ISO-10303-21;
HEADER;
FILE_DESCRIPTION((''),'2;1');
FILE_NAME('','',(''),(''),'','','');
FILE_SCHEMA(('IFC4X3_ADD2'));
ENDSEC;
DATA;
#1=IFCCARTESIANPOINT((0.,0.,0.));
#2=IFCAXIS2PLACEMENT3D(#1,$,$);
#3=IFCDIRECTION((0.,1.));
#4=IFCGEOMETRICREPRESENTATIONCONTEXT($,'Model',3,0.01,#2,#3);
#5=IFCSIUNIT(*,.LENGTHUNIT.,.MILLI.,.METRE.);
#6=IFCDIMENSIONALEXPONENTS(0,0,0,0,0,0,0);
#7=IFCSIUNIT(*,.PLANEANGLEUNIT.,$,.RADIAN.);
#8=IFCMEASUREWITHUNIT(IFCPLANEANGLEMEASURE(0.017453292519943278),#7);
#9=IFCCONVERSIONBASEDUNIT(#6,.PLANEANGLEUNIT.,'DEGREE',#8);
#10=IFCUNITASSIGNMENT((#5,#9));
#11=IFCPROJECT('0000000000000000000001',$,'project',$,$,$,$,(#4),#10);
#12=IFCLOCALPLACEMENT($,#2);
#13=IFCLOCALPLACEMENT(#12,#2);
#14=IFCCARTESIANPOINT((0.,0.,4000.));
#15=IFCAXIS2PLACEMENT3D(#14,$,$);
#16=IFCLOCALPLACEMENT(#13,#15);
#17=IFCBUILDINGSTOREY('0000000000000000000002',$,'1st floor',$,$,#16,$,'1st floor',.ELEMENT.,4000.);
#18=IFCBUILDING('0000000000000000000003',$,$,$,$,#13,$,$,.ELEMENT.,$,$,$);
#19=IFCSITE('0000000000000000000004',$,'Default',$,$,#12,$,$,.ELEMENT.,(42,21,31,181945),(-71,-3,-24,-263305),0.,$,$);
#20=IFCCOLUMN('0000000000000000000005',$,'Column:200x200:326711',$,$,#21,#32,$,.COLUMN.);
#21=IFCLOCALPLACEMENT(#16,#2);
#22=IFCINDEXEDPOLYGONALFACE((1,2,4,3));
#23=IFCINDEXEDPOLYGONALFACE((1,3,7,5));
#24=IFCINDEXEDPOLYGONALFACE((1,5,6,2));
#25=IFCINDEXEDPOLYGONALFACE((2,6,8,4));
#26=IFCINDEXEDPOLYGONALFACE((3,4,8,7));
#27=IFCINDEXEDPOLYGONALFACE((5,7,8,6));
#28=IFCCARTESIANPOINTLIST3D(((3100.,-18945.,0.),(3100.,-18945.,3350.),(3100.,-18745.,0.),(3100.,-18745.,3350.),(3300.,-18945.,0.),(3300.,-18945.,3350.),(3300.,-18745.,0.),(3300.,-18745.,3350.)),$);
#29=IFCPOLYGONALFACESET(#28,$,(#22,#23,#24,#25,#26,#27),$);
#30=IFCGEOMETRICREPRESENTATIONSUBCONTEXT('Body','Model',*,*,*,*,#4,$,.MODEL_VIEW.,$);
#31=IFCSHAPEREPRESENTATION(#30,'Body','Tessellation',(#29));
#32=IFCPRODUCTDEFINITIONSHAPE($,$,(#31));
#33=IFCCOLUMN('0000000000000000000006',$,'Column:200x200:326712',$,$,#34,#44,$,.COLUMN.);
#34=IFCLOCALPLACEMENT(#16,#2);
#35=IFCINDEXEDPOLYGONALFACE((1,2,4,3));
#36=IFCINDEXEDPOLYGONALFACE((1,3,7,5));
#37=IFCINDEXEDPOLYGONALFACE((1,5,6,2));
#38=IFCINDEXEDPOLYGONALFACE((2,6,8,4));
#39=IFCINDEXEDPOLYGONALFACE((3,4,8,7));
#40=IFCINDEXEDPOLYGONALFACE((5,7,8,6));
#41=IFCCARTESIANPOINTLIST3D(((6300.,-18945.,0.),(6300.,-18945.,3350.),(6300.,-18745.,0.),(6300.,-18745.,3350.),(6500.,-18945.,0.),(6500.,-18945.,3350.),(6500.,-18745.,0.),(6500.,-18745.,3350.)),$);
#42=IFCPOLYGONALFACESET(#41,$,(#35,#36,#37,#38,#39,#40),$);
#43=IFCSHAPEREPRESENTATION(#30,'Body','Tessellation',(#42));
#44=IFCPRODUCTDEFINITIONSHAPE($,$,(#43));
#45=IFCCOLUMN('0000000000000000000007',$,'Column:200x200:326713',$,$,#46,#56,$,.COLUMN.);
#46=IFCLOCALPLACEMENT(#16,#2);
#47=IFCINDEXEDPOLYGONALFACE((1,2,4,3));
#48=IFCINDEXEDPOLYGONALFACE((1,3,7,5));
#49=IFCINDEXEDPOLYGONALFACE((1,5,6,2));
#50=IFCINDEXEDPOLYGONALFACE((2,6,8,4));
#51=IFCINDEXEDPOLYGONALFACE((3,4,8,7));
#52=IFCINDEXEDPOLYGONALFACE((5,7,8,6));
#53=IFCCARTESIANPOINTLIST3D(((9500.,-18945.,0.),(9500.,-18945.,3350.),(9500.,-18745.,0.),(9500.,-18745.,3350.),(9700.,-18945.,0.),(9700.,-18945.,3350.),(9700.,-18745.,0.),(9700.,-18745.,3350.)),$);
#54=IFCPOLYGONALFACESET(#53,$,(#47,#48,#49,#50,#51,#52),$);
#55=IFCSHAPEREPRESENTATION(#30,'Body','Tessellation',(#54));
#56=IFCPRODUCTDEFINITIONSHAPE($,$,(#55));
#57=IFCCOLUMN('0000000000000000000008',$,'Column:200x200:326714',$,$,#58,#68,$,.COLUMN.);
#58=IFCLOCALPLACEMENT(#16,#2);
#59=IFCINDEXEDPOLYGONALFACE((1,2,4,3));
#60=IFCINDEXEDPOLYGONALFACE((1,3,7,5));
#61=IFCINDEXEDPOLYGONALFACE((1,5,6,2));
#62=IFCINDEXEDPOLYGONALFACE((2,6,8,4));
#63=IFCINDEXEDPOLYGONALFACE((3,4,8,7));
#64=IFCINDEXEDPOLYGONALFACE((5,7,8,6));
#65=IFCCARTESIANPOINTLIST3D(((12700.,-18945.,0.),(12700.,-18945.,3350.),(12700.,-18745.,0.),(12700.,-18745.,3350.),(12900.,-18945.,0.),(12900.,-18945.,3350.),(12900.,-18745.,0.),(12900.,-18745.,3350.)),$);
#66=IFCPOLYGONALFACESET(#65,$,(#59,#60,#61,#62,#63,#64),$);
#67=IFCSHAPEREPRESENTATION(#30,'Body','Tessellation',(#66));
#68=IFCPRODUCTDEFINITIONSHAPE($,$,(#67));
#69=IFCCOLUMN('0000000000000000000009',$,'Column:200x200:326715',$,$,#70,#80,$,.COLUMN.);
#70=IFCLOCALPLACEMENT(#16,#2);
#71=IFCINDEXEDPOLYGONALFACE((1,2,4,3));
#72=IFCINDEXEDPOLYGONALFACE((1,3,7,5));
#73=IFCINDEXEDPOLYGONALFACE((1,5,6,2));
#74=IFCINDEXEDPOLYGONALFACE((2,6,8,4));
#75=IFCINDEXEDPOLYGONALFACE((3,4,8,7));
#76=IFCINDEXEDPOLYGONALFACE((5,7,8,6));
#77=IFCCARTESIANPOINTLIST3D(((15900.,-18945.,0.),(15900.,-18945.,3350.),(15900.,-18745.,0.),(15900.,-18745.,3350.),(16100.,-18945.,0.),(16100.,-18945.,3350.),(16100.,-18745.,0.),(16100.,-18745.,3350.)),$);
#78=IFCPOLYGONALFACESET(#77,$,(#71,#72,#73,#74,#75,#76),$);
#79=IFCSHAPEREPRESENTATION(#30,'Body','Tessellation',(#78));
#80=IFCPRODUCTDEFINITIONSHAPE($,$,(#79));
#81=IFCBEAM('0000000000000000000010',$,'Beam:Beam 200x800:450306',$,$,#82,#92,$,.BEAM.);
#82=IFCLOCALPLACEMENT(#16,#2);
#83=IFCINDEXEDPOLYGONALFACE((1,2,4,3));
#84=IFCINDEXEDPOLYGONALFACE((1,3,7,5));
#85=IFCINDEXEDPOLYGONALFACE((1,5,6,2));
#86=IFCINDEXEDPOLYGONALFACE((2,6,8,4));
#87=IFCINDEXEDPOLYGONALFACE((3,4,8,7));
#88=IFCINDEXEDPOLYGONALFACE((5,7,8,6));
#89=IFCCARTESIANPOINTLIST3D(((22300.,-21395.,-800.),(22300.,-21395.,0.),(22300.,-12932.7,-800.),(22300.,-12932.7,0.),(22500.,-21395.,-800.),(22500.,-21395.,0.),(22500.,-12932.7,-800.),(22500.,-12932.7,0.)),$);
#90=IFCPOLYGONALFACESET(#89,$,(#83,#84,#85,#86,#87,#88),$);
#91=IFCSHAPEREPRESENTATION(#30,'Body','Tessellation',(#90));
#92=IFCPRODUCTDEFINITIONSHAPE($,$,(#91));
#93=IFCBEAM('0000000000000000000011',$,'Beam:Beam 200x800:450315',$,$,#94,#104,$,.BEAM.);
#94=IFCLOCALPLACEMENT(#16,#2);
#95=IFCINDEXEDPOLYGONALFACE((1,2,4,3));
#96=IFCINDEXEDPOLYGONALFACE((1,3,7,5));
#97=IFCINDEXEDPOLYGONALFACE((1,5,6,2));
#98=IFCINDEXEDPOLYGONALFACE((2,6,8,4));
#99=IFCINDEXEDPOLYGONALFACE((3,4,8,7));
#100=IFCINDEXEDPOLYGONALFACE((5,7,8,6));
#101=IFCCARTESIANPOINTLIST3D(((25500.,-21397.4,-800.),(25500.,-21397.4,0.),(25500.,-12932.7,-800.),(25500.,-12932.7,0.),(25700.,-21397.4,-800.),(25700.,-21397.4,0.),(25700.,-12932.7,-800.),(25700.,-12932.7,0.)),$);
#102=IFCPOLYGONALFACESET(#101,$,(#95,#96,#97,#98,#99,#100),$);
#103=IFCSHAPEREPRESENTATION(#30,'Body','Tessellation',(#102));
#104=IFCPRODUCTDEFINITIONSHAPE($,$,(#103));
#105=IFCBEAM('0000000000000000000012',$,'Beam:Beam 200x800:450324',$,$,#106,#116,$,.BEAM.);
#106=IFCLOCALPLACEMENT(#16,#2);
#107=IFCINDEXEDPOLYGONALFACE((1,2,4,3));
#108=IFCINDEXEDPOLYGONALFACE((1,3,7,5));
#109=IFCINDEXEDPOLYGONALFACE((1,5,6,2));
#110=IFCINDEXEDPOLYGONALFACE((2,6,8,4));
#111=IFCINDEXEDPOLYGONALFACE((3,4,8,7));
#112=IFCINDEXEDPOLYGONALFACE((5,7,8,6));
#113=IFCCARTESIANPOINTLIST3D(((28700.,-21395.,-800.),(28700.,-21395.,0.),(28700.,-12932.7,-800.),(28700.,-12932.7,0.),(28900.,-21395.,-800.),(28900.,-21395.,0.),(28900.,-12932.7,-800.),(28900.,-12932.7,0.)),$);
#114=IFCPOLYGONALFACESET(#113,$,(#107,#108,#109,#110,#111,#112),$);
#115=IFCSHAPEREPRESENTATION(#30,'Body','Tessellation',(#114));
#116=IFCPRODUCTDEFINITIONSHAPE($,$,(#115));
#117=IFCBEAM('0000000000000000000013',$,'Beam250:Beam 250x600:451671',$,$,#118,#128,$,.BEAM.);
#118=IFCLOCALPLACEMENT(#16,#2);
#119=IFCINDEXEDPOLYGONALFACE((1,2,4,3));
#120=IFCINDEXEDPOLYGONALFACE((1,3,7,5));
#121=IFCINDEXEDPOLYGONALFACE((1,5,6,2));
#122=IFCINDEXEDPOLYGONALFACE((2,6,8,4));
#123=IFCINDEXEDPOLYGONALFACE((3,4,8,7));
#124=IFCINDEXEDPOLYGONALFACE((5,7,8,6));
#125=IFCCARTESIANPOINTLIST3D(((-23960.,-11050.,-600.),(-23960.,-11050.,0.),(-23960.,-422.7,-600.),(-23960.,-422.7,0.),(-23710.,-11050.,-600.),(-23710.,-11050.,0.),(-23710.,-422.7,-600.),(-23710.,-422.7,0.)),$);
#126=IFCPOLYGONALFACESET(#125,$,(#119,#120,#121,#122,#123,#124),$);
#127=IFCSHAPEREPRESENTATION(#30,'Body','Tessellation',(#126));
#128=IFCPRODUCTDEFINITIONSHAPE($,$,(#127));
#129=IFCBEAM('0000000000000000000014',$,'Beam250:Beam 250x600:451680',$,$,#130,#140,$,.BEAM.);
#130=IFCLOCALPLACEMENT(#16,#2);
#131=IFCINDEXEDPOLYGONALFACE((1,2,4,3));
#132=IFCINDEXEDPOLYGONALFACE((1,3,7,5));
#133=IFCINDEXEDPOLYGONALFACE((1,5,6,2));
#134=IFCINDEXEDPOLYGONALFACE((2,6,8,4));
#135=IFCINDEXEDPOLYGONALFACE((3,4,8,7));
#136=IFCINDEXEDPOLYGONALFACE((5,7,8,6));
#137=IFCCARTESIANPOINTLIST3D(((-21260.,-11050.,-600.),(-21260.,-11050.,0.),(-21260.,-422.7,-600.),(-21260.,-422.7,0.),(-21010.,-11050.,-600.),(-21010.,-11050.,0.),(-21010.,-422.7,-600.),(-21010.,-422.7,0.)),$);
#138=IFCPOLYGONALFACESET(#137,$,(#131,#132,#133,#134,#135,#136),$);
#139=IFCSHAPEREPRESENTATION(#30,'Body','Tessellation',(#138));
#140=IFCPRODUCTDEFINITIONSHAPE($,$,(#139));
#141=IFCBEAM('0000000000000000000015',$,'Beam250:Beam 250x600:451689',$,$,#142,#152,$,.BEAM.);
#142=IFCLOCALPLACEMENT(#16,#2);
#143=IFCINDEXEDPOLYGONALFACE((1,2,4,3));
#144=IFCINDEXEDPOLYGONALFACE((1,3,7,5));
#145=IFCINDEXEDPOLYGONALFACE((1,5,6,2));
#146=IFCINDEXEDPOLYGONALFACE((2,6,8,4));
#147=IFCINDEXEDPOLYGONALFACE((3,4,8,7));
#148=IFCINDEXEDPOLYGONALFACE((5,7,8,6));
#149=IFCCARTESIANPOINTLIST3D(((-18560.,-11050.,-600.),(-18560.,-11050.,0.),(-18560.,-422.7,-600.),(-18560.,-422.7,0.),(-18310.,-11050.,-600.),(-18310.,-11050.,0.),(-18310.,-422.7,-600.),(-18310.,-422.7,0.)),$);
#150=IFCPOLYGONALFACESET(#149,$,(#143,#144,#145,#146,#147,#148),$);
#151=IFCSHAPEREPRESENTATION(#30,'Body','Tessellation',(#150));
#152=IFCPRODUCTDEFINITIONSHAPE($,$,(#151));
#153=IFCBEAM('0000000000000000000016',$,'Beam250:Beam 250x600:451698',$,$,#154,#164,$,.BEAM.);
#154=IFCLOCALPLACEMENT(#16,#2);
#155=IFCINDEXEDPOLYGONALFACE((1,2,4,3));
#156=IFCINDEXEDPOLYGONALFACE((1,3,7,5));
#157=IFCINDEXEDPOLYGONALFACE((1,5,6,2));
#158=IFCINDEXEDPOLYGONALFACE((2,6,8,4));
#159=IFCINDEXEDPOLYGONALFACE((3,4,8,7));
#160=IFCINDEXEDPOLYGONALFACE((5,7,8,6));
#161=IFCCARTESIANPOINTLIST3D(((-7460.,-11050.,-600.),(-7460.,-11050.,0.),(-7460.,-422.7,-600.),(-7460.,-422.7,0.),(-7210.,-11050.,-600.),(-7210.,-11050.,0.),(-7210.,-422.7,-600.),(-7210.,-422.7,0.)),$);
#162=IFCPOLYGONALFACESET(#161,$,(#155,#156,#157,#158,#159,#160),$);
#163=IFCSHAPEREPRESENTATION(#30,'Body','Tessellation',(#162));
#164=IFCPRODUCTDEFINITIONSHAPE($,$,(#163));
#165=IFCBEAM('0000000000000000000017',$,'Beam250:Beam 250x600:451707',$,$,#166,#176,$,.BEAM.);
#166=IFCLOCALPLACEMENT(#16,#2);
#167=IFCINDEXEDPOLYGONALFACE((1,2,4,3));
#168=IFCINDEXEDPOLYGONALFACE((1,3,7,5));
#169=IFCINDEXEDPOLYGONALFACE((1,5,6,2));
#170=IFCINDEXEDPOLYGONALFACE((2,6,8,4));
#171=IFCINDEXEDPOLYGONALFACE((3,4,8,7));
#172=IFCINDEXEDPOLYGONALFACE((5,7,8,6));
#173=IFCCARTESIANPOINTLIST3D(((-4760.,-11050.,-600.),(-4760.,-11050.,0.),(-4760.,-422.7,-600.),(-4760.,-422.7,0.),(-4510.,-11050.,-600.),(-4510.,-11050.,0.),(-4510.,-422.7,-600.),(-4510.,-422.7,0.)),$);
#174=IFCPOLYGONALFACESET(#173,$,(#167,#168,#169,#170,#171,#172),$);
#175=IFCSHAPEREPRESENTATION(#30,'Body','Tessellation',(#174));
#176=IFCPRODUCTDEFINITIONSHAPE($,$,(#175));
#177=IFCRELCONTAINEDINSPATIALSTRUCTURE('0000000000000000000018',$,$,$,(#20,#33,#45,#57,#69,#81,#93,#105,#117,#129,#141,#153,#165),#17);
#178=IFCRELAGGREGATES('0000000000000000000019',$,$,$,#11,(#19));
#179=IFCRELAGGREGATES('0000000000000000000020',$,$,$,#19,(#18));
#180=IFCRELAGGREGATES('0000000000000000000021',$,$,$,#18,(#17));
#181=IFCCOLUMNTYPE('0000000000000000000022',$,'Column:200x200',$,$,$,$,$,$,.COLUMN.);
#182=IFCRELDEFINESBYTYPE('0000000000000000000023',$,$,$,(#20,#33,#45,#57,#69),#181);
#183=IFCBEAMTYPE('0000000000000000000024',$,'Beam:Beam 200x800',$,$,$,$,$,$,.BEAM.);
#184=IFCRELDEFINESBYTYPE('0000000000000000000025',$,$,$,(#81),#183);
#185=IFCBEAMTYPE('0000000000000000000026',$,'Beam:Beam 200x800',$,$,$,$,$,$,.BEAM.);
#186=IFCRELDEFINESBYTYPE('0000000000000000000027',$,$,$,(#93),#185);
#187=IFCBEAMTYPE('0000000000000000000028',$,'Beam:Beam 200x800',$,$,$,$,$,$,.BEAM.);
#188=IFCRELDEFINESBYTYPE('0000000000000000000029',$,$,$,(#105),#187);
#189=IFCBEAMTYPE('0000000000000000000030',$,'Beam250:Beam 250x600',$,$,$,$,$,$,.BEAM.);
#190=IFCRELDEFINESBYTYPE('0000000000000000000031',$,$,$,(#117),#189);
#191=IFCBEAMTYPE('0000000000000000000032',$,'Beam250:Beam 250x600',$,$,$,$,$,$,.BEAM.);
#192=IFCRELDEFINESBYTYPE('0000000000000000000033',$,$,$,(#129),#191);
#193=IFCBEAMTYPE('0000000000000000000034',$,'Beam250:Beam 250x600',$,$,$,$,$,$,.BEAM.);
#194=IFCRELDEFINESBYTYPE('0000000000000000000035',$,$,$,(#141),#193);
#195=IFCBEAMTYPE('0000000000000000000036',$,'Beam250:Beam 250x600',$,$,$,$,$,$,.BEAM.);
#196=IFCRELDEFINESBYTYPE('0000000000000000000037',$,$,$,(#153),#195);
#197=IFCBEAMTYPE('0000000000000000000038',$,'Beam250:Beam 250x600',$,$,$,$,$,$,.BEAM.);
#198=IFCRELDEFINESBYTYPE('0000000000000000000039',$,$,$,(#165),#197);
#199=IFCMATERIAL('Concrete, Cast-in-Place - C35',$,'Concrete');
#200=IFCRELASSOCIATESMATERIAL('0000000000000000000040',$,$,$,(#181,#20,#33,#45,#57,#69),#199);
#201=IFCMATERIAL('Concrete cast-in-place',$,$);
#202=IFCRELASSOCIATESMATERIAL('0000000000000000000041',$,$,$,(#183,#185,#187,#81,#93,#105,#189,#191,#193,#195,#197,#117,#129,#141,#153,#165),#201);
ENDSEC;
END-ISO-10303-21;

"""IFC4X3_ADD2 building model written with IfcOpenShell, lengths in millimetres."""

from ifc_helpers import new_model, entity, si_unit, converted_unit, direction, frame, frame_2d, origin, place, context, subcontext, project, spatial, rectangle, extrude, source, transform, mapped, material, material_profile, profile_set, profile_usage, type_object, type_shapes, element, save


model = new_model("IFC4X3_ADD2")

# Units and contexts
model_context = context("Model", 3, precision=0.01, world=origin(), true_north=direction((0.0, 1.0)))
body_context = subcontext(model_context, "Body", "Model", "MODEL_VIEW")
ifc_project = project(units=[si_unit("LENGTHUNIT", "METRE", prefix="MILLI"), converted_unit("PLANEANGLEUNIT", "DEGREE", entity("IfcPlaneAngleMeasure", 0.017453292519943278), si_unit("PLANEANGLEUNIT", "RADIAN"), dimensions=[0, 0, 0, 0, 0, 0, 0])], contexts=[model_context])

# Site, building, storey
site_placement = place(None, origin())
site = spatial("IfcSite", under=ifc_project, at=site_placement, Name="Default", CompositionType="ELEMENT", RefLatitude=(42, 21, 31, 181945), RefLongitude=(-71, -3, -24, -263305), RefElevation=0.0)
building_placement = place(site_placement, origin())
building = spatial("IfcBuilding", under=site, at=building_placement, CompositionType="ELEMENT")
storey_placement = place(building_placement, frame((0.0, 0.0, 4000.0)))
storey = spatial("IfcBuildingStorey", under=building, at=storey_placement, Name="1st floor", LongName="1st floor", CompositionType="ELEMENT", Elevation=4000.0)

# Columns
ifc_material_1 = material(Name="Concrete, Cast-in-Place - C35", Category="Concrete")
ifc_material_profile_1 = material_profile(ifc_material_1, rectangle(XDim=200.0, YDim=200.0, at=frame_2d((0.0, 0.0), x_axis=(1.0, 0.0))), Name="200x200")
ifc_profile_set_1 = profile_set([ifc_material_profile_1], Name="200x200")
ifc_profile_usage_1 = profile_usage(ifc_profile_set_1)
column_type_1 = type_object("IfcColumnType", Name="Column:200x200", PredefinedType="COLUMN", material=ifc_profile_set_1)
shared_shape_1 = source(origin(), body_context, "Body", "SweptSolid", [
    extrude(rectangle(XDim=200.0, YDim=200.0, at=frame_2d((0.0, 0.0), x_axis=(1.0, 0.0))), frame((0.0, 0.0, 4000.0), z_axis=(0.0, 0.0, 1.0), x_axis=(-1.0, 0.0, 0.0)), (0.0, 0.0, 1.0), 3350.0),
])
type_shapes(column_type_1, [shared_shape_1])
for number, where, name in (
    (1, (3200.0, -18845.0, -4000.0), "Column:200x200:326711"),
    (2, (6400.0, -18845.0, -4000.0), "Column:200x200:326712"),
    (3, (9600.0, -18845.0, -4000.0), "Column:200x200:326713"),
    (4, (12800.0, -18845.0, -4000.0), "Column:200x200:326714"),
    (5, (16000.0, -18845.0, -4000.0), "Column:200x200:326715"),
):
    element("IfcColumn", number, at=place(storey_placement, frame(where)), inside=storey, type_object=column_type_1, material=ifc_profile_usage_1, Name=name, PredefinedType="COLUMN", context=body_context, shape_type="MappedRepresentation", body=[
        mapped(shared_shape_1, transform((0.0, 0.0, 0.0), scale=1.0)),
    ])

# Beams
ifc_material_2 = material(Name="Concrete cast-in-place")
ifc_material_profile_2 = material_profile(ifc_material_2, rectangle(XDim=800.0, YDim=200.0, at=frame_2d((0.0, 0.0), x_axis=(0.0, 1.0))), Name="Beam 200x800")
ifc_profile_set_2 = profile_set([ifc_material_profile_2], Name="Beam 200x800")
ifc_profile_usage_2 = profile_usage(ifc_profile_set_2, cardinal=8)
beam_type_1 = type_object("IfcBeamType", Name="Beam:Beam 200x800", PredefinedType="BEAM", material=ifc_profile_set_2)
shared_shape_2 = source(origin(), body_context, "Body", "SweptSolid", [
    extrude(rectangle(XDim=800.0, YDim=200.0, at=frame_2d((0.0, 0.0), x_axis=(0.0, 1.0))), frame((22400.0, -12932.7, 3600.0), z_axis=(0.0, -1.0, 0.0), x_axis=(-1.0, 0.0, 0.0)), (0.0, 0.0, 1.0), 8462.3),
])
type_shapes(beam_type_1, [shared_shape_2])
beam_1_placement = place(storey_placement, frame((0.0, 0.0, -4000.0)))
element("IfcBeam", 6, at=beam_1_placement, inside=storey, type_object=beam_type_1, material=ifc_profile_usage_2, Name="Beam:Beam 200x800:450306", PredefinedType="BEAM", context=body_context, shape_type="MappedRepresentation", body=[
    mapped(shared_shape_2, transform((0.0, 0.0, 0.0), scale=1.0)),
])
beam_type_2 = type_object("IfcBeamType", Name="Beam:Beam 200x800", PredefinedType="BEAM", material=ifc_profile_set_2)
shared_shape_3 = source(origin(), body_context, "Body", "SweptSolid", [
    extrude(rectangle(XDim=800.0, YDim=200.0, at=frame_2d((0.0, 0.0), x_axis=(0.0, 1.0))), frame((25600.0, -12932.7, 3600.0), z_axis=(0.0, -1.0, 0.0), x_axis=(-1.0, 0.0, 0.0)), (0.0, 0.0, 1.0), 8464.7),
])
type_shapes(beam_type_2, [shared_shape_3])
beam_2_placement = place(storey_placement, frame((0.0, 0.0, -4000.0)))
element("IfcBeam", 7, at=beam_2_placement, inside=storey, type_object=beam_type_2, material=ifc_profile_usage_2, Name="Beam:Beam 200x800:450315", PredefinedType="BEAM", context=body_context, shape_type="MappedRepresentation", body=[
    mapped(shared_shape_3, transform((0.0, 0.0, 0.0), scale=1.0)),
])
beam_type_3 = type_object("IfcBeamType", Name="Beam:Beam 200x800", PredefinedType="BEAM", material=ifc_profile_set_2)
shared_shape_4 = source(origin(), body_context, "Body", "SweptSolid", [
    extrude(rectangle(XDim=800.0, YDim=200.0, at=frame_2d((0.0, 0.0), x_axis=(0.0, 1.0))), frame((28800.0, -12932.7, 3600.0), z_axis=(0.0, -1.0, 0.0), x_axis=(-1.0, 0.0, 0.0)), (0.0, 0.0, 1.0), 8462.3),
])
type_shapes(beam_type_3, [shared_shape_4])
beam_3_placement = place(storey_placement, frame((0.0, 0.0, -4000.0)))
element("IfcBeam", 8, at=beam_3_placement, inside=storey, type_object=beam_type_3, material=ifc_profile_usage_2, Name="Beam:Beam 200x800:450324", PredefinedType="BEAM", context=body_context, shape_type="MappedRepresentation", body=[
    mapped(shared_shape_4, transform((0.0, 0.0, 0.0), scale=1.0)),
])
ifc_material_profile_3 = material_profile(ifc_material_2, rectangle(XDim=600.0, YDim=250.0, at=frame_2d((0.0, 0.0), x_axis=(0.0, 1.0))), Name="Beam 250x600")
ifc_profile_set_3 = profile_set([ifc_material_profile_3], Name="Beam 250x600")
ifc_profile_usage_3 = profile_usage(ifc_profile_set_3, cardinal=8)
beam_type_4 = type_object("IfcBeamType", Name="Beam250:Beam 250x600", PredefinedType="BEAM", material=ifc_profile_set_3)
shared_shape_5 = source(origin(), body_context, "Body", "SweptSolid", [
    extrude(rectangle(XDim=600.0, YDim=250.0, at=frame_2d((0.0, 0.0), x_axis=(0.0, 1.0))), frame((-23835.0, -11050.0, 3700.0), z_axis=(0.0, 1.0, 0.0), x_axis=(-1.0, 0.0, 0.0)), (0.0, 0.0, 1.0), 10627.3),
])
type_shapes(beam_type_4, [shared_shape_5])
beam_4_placement = place(storey_placement, frame((0.0, 0.0, -4000.0)))
element("IfcBeam", 9, at=beam_4_placement, inside=storey, type_object=beam_type_4, material=ifc_profile_usage_3, Name="Beam250:Beam 250x600:451671", PredefinedType="BEAM", context=body_context, shape_type="MappedRepresentation", body=[
    mapped(shared_shape_5, transform((0.0, 0.0, 0.0), scale=1.0)),
])
beam_type_5 = type_object("IfcBeamType", Name="Beam250:Beam 250x600", PredefinedType="BEAM", material=ifc_profile_set_3)
shared_shape_6 = source(origin(), body_context, "Body", "SweptSolid", [
    extrude(rectangle(XDim=600.0, YDim=250.0, at=frame_2d((0.0, 0.0), x_axis=(0.0, 1.0))), frame((-21135.0, -11050.0, 3700.0), z_axis=(0.0, 1.0, 0.0), x_axis=(-1.0, 0.0, 0.0)), (0.0, 0.0, 1.0), 10627.3),
])
type_shapes(beam_type_5, [shared_shape_6])
beam_5_placement = place(storey_placement, frame((0.0, 0.0, -4000.0)))
element("IfcBeam", 10, at=beam_5_placement, inside=storey, type_object=beam_type_5, material=ifc_profile_usage_3, Name="Beam250:Beam 250x600:451680", PredefinedType="BEAM", context=body_context, shape_type="MappedRepresentation", body=[
    mapped(shared_shape_6, transform((0.0, 0.0, 0.0), scale=1.0)),
])
beam_type_6 = type_object("IfcBeamType", Name="Beam250:Beam 250x600", PredefinedType="BEAM", material=ifc_profile_set_3)
shared_shape_7 = source(origin(), body_context, "Body", "SweptSolid", [
    extrude(rectangle(XDim=600.0, YDim=250.0, at=frame_2d((0.0, 0.0), x_axis=(0.0, 1.0))), frame((-18435.0, -11050.0, 3700.0), z_axis=(0.0, 1.0, 0.0), x_axis=(-1.0, 0.0, 0.0)), (0.0, 0.0, 1.0), 10627.3),
])
type_shapes(beam_type_6, [shared_shape_7])
beam_6_placement = place(storey_placement, frame((0.0, 0.0, -4000.0)))
element("IfcBeam", 11, at=beam_6_placement, inside=storey, type_object=beam_type_6, material=ifc_profile_usage_3, Name="Beam250:Beam 250x600:451689", PredefinedType="BEAM", context=body_context, shape_type="MappedRepresentation", body=[
    mapped(shared_shape_7, transform((0.0, 0.0, 0.0), scale=1.0)),
])
beam_type_7 = type_object("IfcBeamType", Name="Beam250:Beam 250x600", PredefinedType="BEAM", material=ifc_profile_set_3)
shared_shape_8 = source(origin(), body_context, "Body", "SweptSolid", [
    extrude(rectangle(XDim=600.0, YDim=250.0, at=frame_2d((0.0, 0.0), x_axis=(0.0, 1.0))), frame((-7335.0, -11050.0, 3700.0), z_axis=(0.0, 1.0, 0.0), x_axis=(-1.0, 0.0, 0.0)), (0.0, 0.0, 1.0), 10627.3),
])
type_shapes(beam_type_7, [shared_shape_8])
beam_7_placement = place(storey_placement, frame((0.0, 0.0, -4000.0)))
element("IfcBeam", 12, at=beam_7_placement, inside=storey, type_object=beam_type_7, material=ifc_profile_usage_3, Name="Beam250:Beam 250x600:451698", PredefinedType="BEAM", context=body_context, shape_type="MappedRepresentation", body=[
    mapped(shared_shape_8, transform((0.0, 0.0, 0.0), scale=1.0)),
])
beam_type_8 = type_object("IfcBeamType", Name="Beam250:Beam 250x600", PredefinedType="BEAM", material=ifc_profile_set_3)
shared_shape_9 = source(origin(), body_context, "Body", "SweptSolid", [
    extrude(rectangle(XDim=600.0, YDim=250.0, at=frame_2d((0.0, 0.0), x_axis=(0.0, 1.0))), frame((-4635.0, -11050.0, 3700.0), z_axis=(0.0, 1.0, 0.0), x_axis=(-1.0, 0.0, 0.0)), (0.0, 0.0, 1.0), 10627.3),
])
type_shapes(beam_type_8, [shared_shape_9])
beam_8_placement = place(storey_placement, frame((0.0, 0.0, -4000.0)))
element("IfcBeam", 13, at=beam_8_placement, inside=storey, type_object=beam_type_8, material=ifc_profile_usage_3, Name="Beam250:Beam 250x600:451707", PredefinedType="BEAM", context=body_context, shape_type="MappedRepresentation", body=[
    mapped(shared_shape_9, transform((0.0, 0.0, 0.0), scale=1.0)),
])

save(model, "model.ifc")
